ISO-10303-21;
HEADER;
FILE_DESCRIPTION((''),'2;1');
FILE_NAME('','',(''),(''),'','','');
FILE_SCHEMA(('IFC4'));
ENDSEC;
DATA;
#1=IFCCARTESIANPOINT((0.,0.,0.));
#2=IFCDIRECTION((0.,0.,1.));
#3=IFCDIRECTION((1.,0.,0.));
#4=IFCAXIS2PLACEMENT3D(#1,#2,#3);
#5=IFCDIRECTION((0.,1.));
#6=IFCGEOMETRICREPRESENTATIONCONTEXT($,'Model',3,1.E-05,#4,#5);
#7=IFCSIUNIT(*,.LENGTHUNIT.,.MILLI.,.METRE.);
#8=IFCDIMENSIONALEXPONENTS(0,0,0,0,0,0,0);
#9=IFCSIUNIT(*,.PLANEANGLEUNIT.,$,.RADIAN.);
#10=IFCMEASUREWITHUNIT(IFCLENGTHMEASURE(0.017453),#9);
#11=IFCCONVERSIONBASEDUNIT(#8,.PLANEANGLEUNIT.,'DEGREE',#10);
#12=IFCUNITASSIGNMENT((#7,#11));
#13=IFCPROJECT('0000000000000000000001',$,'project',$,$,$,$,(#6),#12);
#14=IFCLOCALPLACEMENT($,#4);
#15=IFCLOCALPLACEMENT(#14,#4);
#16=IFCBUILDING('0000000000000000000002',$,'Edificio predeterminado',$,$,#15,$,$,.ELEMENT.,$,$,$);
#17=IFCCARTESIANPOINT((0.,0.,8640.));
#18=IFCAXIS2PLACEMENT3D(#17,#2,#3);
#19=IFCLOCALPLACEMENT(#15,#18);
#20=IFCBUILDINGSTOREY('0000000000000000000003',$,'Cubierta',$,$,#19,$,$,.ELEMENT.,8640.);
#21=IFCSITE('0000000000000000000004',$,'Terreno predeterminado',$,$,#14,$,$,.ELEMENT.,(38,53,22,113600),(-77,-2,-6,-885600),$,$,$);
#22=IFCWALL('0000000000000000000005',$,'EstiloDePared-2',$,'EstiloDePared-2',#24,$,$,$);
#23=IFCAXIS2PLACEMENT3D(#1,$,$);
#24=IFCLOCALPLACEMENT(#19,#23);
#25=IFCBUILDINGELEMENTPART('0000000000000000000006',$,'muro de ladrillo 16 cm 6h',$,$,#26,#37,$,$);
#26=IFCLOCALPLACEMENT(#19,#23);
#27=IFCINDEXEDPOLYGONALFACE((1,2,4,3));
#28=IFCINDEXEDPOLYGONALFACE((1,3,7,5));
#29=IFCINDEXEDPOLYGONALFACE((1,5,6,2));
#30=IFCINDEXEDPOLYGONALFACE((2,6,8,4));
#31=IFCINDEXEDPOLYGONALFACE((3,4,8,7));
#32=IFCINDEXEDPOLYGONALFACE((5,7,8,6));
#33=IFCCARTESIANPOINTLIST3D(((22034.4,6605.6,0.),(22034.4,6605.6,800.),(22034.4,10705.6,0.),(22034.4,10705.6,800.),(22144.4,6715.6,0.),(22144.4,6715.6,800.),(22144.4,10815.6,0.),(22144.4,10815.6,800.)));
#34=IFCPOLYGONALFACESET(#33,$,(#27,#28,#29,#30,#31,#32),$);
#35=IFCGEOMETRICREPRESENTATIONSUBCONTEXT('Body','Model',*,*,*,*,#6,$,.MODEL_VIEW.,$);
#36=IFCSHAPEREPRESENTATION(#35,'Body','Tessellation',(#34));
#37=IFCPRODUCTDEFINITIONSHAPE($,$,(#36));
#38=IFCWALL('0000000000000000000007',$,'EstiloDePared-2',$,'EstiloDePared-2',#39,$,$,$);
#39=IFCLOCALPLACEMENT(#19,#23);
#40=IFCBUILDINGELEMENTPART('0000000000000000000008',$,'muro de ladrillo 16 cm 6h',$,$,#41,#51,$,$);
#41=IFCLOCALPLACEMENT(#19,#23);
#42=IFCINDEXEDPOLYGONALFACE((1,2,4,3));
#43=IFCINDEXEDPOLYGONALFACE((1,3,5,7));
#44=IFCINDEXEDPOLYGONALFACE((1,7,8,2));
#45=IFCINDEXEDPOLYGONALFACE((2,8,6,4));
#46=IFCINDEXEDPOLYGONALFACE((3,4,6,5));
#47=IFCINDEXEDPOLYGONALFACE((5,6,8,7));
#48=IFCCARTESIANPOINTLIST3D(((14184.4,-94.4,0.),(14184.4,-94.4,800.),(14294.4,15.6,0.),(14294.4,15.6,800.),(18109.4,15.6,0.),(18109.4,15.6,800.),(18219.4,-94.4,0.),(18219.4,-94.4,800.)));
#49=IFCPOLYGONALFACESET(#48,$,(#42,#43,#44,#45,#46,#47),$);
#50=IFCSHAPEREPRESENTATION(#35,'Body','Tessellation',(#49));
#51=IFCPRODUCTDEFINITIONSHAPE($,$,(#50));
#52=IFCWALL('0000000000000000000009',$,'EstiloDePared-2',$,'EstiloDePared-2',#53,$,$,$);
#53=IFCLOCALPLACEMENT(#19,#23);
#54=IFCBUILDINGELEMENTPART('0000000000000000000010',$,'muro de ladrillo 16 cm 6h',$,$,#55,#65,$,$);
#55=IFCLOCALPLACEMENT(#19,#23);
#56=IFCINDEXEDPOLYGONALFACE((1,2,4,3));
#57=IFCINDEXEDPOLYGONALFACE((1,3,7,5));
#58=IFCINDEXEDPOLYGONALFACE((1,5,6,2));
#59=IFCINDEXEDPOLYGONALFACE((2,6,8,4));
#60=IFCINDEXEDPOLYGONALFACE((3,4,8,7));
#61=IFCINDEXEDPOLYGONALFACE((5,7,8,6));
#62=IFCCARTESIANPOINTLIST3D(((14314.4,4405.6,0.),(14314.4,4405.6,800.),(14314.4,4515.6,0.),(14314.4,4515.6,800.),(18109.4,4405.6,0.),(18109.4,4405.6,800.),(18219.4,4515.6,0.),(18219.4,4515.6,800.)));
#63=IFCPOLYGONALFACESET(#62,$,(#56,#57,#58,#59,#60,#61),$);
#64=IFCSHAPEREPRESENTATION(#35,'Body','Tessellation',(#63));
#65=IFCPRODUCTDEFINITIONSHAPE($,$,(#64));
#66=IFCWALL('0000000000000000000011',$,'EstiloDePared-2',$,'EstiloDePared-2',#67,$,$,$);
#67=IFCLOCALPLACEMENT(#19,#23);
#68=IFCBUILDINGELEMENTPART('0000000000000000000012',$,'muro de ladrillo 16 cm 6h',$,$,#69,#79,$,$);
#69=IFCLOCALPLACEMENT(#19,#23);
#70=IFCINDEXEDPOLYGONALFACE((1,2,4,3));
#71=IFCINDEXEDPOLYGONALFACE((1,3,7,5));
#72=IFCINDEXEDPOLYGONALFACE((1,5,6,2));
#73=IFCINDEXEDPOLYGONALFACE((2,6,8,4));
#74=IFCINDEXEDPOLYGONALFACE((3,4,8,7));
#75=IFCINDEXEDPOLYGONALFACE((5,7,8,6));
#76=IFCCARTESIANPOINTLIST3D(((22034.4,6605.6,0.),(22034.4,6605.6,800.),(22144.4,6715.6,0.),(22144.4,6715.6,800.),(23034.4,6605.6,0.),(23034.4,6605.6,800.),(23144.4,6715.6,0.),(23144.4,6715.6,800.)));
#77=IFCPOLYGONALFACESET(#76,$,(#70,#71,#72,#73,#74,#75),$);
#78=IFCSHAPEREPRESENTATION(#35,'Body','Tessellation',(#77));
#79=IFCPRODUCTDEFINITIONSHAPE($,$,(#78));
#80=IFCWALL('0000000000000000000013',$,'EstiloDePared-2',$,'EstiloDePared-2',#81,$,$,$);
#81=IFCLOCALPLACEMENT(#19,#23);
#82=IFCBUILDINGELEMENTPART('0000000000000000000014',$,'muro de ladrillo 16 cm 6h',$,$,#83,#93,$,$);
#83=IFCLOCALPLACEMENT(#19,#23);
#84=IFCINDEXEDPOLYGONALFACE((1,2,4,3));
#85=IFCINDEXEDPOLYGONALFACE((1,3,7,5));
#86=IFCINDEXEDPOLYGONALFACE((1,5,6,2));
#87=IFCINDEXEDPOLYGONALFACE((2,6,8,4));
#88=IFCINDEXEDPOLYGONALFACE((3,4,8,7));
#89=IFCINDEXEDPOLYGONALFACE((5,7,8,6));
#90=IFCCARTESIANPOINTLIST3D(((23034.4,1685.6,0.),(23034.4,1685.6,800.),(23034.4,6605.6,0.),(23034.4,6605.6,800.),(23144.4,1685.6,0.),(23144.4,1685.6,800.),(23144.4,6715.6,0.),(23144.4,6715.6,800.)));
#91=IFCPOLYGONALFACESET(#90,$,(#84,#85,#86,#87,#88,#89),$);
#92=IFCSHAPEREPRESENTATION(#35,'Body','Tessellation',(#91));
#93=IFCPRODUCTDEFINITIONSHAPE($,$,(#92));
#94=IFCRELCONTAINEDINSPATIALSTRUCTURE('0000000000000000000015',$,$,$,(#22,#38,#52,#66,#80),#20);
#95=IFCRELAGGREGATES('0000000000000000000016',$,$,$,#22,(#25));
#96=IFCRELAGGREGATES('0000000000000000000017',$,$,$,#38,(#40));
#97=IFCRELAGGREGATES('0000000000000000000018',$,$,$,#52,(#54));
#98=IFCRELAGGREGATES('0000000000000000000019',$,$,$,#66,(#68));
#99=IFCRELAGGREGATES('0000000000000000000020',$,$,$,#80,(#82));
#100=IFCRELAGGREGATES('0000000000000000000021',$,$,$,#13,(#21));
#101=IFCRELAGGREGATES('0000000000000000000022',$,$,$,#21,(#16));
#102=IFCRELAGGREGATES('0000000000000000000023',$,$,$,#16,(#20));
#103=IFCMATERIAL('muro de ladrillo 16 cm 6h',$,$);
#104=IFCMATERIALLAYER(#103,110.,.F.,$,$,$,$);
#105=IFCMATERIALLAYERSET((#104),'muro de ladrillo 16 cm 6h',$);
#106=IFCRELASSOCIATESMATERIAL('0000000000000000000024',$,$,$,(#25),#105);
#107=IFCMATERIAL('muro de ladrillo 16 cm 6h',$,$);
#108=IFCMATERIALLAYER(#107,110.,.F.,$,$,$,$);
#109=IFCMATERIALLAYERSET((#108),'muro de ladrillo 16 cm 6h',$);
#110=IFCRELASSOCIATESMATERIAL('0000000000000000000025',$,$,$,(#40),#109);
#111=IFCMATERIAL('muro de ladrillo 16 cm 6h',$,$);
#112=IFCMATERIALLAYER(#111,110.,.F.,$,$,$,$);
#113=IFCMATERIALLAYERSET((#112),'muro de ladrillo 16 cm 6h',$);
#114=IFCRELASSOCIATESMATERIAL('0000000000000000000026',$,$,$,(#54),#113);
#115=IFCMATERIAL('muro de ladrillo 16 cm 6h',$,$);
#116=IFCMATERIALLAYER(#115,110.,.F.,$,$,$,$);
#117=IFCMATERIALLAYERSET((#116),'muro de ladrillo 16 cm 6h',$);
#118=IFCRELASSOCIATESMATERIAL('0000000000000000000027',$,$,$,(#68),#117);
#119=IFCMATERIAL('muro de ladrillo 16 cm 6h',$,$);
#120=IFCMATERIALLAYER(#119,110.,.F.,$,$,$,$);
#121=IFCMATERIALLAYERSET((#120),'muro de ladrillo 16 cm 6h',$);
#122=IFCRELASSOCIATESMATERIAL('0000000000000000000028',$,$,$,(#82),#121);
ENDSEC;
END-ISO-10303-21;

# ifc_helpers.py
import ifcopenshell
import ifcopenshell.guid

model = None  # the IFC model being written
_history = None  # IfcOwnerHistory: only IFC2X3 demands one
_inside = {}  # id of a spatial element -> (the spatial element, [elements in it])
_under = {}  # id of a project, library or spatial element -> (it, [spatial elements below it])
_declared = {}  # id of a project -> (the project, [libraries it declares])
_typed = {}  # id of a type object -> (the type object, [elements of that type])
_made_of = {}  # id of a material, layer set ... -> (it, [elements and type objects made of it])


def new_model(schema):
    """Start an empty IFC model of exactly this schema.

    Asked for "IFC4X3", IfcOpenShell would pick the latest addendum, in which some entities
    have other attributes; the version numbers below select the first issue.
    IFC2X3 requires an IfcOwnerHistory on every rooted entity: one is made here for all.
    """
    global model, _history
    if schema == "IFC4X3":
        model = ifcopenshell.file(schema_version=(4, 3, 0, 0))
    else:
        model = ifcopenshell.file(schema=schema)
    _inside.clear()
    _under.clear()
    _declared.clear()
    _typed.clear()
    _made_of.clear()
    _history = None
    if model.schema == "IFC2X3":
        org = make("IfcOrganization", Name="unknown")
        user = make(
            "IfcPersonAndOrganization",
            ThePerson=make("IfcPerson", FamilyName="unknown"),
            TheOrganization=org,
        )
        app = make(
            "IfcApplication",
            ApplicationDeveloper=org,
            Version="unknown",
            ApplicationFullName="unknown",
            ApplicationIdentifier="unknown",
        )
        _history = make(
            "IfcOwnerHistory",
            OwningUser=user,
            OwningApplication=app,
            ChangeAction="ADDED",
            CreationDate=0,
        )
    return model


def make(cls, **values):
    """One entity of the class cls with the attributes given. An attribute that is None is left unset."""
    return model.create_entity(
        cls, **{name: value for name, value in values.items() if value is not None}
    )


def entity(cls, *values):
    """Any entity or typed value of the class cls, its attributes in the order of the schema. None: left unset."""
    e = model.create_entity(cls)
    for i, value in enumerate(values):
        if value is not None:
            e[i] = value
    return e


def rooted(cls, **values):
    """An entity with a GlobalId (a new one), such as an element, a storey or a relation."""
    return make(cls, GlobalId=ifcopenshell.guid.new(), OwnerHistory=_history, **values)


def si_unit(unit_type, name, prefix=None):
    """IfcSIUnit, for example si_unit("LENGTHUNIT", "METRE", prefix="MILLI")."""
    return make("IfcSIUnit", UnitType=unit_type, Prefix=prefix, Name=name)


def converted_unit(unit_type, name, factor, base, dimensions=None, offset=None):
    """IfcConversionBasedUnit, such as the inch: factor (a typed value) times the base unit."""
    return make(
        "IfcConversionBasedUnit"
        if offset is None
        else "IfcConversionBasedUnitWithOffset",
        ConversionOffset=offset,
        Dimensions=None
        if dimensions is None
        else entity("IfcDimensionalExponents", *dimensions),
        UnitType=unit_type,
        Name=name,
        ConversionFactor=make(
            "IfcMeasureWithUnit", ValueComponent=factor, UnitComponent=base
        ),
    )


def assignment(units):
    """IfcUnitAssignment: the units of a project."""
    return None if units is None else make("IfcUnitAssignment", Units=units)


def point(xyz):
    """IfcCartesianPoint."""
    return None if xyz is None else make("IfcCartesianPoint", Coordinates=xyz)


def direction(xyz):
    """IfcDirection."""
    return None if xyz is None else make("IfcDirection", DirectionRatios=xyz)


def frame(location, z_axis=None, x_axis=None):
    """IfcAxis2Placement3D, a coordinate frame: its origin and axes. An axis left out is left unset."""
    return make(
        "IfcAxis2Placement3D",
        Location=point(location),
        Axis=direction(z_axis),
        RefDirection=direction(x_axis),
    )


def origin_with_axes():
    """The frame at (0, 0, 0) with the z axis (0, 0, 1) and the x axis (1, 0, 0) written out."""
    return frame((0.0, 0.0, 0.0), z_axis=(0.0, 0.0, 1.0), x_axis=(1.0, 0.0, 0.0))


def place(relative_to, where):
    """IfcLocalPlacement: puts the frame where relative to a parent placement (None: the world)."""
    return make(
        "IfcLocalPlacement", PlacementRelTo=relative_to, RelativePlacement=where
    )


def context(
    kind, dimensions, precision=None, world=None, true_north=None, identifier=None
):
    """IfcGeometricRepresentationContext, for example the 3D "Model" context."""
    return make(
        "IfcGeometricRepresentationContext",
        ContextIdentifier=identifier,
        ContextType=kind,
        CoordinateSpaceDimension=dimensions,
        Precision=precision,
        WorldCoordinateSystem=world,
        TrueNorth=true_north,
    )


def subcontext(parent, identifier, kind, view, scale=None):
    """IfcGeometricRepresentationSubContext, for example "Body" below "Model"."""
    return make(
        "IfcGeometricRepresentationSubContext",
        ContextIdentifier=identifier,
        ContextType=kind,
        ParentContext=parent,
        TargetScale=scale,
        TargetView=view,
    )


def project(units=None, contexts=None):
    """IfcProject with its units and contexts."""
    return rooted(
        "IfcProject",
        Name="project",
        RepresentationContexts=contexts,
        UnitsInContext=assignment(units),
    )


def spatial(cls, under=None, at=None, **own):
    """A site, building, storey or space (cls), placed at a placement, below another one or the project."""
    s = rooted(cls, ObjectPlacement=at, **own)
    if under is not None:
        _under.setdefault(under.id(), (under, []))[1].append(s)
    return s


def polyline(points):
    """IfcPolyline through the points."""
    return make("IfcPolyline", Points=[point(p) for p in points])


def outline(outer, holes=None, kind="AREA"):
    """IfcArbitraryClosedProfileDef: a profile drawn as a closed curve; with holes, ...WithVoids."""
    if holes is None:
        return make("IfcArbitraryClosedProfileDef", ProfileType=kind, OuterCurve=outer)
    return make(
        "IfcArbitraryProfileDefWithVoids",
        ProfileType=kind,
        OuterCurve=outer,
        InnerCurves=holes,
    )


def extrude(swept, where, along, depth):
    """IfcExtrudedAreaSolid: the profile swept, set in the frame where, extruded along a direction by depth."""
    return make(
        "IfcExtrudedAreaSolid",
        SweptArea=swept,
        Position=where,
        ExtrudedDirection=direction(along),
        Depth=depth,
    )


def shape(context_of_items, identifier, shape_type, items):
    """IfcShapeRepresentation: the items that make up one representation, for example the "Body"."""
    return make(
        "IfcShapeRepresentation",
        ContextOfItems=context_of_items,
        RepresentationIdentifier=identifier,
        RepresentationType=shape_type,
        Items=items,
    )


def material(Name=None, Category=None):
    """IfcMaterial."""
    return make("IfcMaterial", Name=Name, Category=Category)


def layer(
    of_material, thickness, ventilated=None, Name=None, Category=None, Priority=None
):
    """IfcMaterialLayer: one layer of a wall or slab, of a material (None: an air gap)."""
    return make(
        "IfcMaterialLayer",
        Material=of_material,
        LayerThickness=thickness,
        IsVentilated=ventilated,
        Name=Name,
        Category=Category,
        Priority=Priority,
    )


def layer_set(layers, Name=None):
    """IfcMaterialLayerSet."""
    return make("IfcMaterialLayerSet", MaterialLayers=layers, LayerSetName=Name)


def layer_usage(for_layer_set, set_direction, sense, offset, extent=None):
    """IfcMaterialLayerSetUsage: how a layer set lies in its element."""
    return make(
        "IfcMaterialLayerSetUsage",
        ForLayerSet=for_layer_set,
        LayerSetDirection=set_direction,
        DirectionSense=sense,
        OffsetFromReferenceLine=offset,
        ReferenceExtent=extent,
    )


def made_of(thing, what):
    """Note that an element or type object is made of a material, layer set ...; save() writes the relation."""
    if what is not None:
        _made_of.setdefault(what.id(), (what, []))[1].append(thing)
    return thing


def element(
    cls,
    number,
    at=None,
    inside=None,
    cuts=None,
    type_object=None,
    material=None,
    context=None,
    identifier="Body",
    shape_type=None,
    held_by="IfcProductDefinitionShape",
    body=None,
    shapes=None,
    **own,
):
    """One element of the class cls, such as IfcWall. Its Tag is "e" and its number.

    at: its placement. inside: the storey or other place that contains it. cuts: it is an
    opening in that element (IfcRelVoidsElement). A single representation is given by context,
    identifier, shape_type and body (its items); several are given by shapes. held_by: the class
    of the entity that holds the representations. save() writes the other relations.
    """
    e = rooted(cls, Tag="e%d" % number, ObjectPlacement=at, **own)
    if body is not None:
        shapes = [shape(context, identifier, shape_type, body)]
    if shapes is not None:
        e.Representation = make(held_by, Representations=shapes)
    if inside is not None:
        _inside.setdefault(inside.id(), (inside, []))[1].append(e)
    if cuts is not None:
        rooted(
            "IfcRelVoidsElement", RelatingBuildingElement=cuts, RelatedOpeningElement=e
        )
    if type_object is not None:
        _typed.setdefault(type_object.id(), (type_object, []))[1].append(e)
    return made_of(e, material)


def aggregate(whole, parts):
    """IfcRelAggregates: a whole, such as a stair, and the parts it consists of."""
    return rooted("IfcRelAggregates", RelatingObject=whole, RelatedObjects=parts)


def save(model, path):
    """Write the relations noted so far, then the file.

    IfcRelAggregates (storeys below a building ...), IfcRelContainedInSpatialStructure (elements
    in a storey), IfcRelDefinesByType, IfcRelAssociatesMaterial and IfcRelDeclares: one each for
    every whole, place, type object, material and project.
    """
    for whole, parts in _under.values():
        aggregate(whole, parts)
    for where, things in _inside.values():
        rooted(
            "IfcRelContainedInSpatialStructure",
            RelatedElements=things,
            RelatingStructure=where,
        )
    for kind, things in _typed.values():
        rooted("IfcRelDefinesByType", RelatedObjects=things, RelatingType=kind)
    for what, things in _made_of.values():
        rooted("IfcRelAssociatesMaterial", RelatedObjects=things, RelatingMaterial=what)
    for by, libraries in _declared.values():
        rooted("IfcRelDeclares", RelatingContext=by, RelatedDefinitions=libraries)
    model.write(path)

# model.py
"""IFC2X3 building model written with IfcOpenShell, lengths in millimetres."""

from ifc_helpers import new_model, entity, si_unit, converted_unit, direction, frame, origin_with_axes, place, context, subcontext, project, spatial, polyline, outline, extrude, material, layer, layer_set, layer_usage, element, aggregate, save


model = new_model("IFC2X3")

# Units and contexts
model_context = context("Model", 3, precision=1e-05, world=origin_with_axes(), true_north=direction((0.0, 1.0)))
body_context = subcontext(model_context, "Body", "Model", "MODEL_VIEW")
ifc_project = project(units=[si_unit("LENGTHUNIT", "METRE", prefix="MILLI"), converted_unit("PLANEANGLEUNIT", "DEGREE", entity("IfcLengthMeasure", 0.017453), si_unit("PLANEANGLEUNIT", "RADIAN"), dimensions=[0, 0, 0, 0, 0, 0, 0])], contexts=[model_context])

# Site, building, storey
site_placement = place(None, origin_with_axes())
site = spatial("IfcSite", under=ifc_project, at=site_placement, Name="Terreno predeterminado", CompositionType="ELEMENT", RefLatitude=(38, 53, 22, 113600), RefLongitude=(-77, -2, -6, -885600))
building_placement = place(site_placement, origin_with_axes())
building = spatial("IfcBuilding", under=site, at=building_placement, Name="Edificio predeterminado", CompositionType="ELEMENT")
storey_placement = place(building_placement, frame((0.0, 0.0, 8640.0), z_axis=(0.0, 0.0, 1.0), x_axis=(1.0, 0.0, 0.0)))
storey = spatial("IfcBuildingStorey", under=building, at=storey_placement, Name="Cubierta", CompositionType="ELEMENT", Elevation=8640.0)

# Wall, building element part
wall_1_placement = place(storey_placement, frame((22089.4, 10760.6, 0.0), z_axis=(0.0, 0.0, 1.0), x_axis=(0.0, -1.0, 0.0)))
wall_1 = element("IfcWall", 1, at=wall_1_placement, inside=storey, Name="EstiloDePared-2", ObjectType="EstiloDePared-2")
ifc_material_1 = material(Name="muro de ladrillo 16 cm 6h")
ifc_layer_1 = layer(ifc_material_1, 110.0, ventilated=False)
ifc_layer_set_1 = layer_set([ifc_layer_1], Name="muro de ladrillo 16 cm 6h")
ifc_layer_usage_1 = layer_usage(ifc_layer_set_1, "AXIS2", "NEGATIVE", -55.0)
building_element_part_1_placement = place(wall_1_placement, origin_with_axes())
building_element_part_1 = element("IfcBuildingElementPart", 2, at=building_element_part_1_placement, material=ifc_layer_usage_1, Name="muro de ladrillo 16 cm 6h", context=body_context, shape_type="SweptSolid", body=[
    extrude(outline(polyline([(4045.0, 55.0), (4155.0, -55.0), (55.0, -55.0), (-55.0, 55.0), (4045.0, 55.0)])), origin_with_axes(), (0.0, 0.0, 1.0), 800.0),
])
aggregate(wall_1, [building_element_part_1])

# Walls, building element parts
wall_2_placement = place(storey_placement, frame((18164.4, -39.4, 0.0), z_axis=(0.0, 0.0, 1.0), x_axis=(-1.0, 0.0, 0.0)))
wall_2 = element("IfcWall", 3, at=wall_2_placement, inside=storey, Name="EstiloDePared-2", ObjectType="EstiloDePared-2")
ifc_material_2 = material(Name="muro de ladrillo 16 cm 6h")
ifc_layer_2 = layer(ifc_material_2, 110.0, ventilated=False)
ifc_layer_set_2 = layer_set([ifc_layer_2], Name="muro de ladrillo 16 cm 6h")
ifc_layer_usage_2 = layer_usage(ifc_layer_set_2, "AXIS2", "NEGATIVE", -55.0)
building_element_part_2_placement = place(wall_2_placement, origin_with_axes())
building_element_part_2 = element("IfcBuildingElementPart", 4, at=building_element_part_2_placement, material=ifc_layer_usage_2, Name="muro de ladrillo 16 cm 6h", context=body_context, shape_type="SweptSolid", body=[
    extrude(outline(polyline([(3980.0, 55.0), (3870.0, -55.0), (55.0, -55.0), (-55.0, 55.0), (3980.0, 55.0)])), origin_with_axes(), (0.0, 0.0, 1.0), 800.0),
])
aggregate(wall_2, [building_element_part_2])
wall_3_placement = place(storey_placement, frame((18164.4, 4460.6, 0.0), z_axis=(0.0, 0.0, 1.0), x_axis=(-1.0, 0.0, 0.0)))
wall_3 = element("IfcWall", 5, at=wall_3_placement, inside=storey, Name="EstiloDePared-2", ObjectType="EstiloDePared-2")
ifc_material_3 = material(Name="muro de ladrillo 16 cm 6h")
ifc_layer_3 = layer(ifc_material_3, 110.0, ventilated=False)
ifc_layer_set_3 = layer_set([ifc_layer_3], Name="muro de ladrillo 16 cm 6h")
ifc_layer_usage_3 = layer_usage(ifc_layer_set_3, "AXIS2", "NEGATIVE", -55.0)
building_element_part_3_placement = place(wall_3_placement, origin_with_axes())
building_element_part_3 = element("IfcBuildingElementPart", 6, at=building_element_part_3_placement, material=ifc_layer_usage_3, Name="muro de ladrillo 16 cm 6h", context=body_context, shape_type="SweptSolid", body=[
    extrude(outline(polyline([(3850.0, 55.0), (3850.0, -55.0), (-55.0, -55.0), (55.0, 55.0), (3850.0, 55.0)])), origin_with_axes(), (0.0, 0.0, 1.0), 800.0),
])
aggregate(wall_3, [building_element_part_3])
wall_4_placement = place(storey_placement, frame((22089.4, 6660.6, 0.0), z_axis=(0.0, 0.0, 1.0), x_axis=(1.0, 0.0, 0.0)))
wall_4 = element("IfcWall", 7, at=wall_4_placement, inside=storey, Name="EstiloDePared-2", ObjectType="EstiloDePared-2")
ifc_material_4 = material(Name="muro de ladrillo 16 cm 6h")
ifc_layer_4 = layer(ifc_material_4, 110.0, ventilated=False)
ifc_layer_set_4 = layer_set([ifc_layer_4], Name="muro de ladrillo 16 cm 6h")
ifc_layer_usage_4 = layer_usage(ifc_layer_set_4, "AXIS2", "NEGATIVE", -55.0)
building_element_part_4_placement = place(wall_4_placement, origin_with_axes())
building_element_part_4 = element("IfcBuildingElementPart", 8, at=building_element_part_4_placement, material=ifc_layer_usage_4, Name="muro de ladrillo 16 cm 6h", context=body_context, shape_type="SweptSolid", body=[
    extrude(outline(polyline([(1055.0, 55.0), (945.0, -55.0), (-55.0, -55.0), (55.0, 55.0), (1055.0, 55.0)])), origin_with_axes(), (0.0, 0.0, 1.0), 800.0),
])
aggregate(wall_4, [building_element_part_4])
wall_5_placement = place(storey_placement, frame((23089.4, 6660.6, 0.0), z_axis=(0.0, 0.0, 1.0), x_axis=(0.0, -1.0, 0.0)))
wall_5 = element("IfcWall", 9, at=wall_5_placement, inside=storey, Name="EstiloDePared-2", ObjectType="EstiloDePared-2")
ifc_material_5 = material(Name="muro de ladrillo 16 cm 6h")
ifc_layer_5 = layer(ifc_material_5, 110.0, ventilated=False)
ifc_layer_set_5 = layer_set([ifc_layer_5], Name="muro de ladrillo 16 cm 6h")
ifc_layer_usage_5 = layer_usage(ifc_layer_set_5, "AXIS2", "NEGATIVE", -55.0)
building_element_part_5_placement = place(wall_5_placement, origin_with_axes())
building_element_part_5 = element("IfcBuildingElementPart", 10, at=building_element_part_5_placement, material=ifc_layer_usage_5, Name="muro de ladrillo 16 cm 6h", context=body_context, shape_type="SweptSolid", body=[
    extrude(outline(polyline([(4975.0, 55.0), (4975.0, -55.0), (55.0, -55.0), (-55.0, 55.0), (4975.0, 55.0)])), origin_with_axes(), (0.0, 0.0, 1.0), 800.0),
])
aggregate(wall_5, [building_element_part_5])

save(model, "model.ifc")
